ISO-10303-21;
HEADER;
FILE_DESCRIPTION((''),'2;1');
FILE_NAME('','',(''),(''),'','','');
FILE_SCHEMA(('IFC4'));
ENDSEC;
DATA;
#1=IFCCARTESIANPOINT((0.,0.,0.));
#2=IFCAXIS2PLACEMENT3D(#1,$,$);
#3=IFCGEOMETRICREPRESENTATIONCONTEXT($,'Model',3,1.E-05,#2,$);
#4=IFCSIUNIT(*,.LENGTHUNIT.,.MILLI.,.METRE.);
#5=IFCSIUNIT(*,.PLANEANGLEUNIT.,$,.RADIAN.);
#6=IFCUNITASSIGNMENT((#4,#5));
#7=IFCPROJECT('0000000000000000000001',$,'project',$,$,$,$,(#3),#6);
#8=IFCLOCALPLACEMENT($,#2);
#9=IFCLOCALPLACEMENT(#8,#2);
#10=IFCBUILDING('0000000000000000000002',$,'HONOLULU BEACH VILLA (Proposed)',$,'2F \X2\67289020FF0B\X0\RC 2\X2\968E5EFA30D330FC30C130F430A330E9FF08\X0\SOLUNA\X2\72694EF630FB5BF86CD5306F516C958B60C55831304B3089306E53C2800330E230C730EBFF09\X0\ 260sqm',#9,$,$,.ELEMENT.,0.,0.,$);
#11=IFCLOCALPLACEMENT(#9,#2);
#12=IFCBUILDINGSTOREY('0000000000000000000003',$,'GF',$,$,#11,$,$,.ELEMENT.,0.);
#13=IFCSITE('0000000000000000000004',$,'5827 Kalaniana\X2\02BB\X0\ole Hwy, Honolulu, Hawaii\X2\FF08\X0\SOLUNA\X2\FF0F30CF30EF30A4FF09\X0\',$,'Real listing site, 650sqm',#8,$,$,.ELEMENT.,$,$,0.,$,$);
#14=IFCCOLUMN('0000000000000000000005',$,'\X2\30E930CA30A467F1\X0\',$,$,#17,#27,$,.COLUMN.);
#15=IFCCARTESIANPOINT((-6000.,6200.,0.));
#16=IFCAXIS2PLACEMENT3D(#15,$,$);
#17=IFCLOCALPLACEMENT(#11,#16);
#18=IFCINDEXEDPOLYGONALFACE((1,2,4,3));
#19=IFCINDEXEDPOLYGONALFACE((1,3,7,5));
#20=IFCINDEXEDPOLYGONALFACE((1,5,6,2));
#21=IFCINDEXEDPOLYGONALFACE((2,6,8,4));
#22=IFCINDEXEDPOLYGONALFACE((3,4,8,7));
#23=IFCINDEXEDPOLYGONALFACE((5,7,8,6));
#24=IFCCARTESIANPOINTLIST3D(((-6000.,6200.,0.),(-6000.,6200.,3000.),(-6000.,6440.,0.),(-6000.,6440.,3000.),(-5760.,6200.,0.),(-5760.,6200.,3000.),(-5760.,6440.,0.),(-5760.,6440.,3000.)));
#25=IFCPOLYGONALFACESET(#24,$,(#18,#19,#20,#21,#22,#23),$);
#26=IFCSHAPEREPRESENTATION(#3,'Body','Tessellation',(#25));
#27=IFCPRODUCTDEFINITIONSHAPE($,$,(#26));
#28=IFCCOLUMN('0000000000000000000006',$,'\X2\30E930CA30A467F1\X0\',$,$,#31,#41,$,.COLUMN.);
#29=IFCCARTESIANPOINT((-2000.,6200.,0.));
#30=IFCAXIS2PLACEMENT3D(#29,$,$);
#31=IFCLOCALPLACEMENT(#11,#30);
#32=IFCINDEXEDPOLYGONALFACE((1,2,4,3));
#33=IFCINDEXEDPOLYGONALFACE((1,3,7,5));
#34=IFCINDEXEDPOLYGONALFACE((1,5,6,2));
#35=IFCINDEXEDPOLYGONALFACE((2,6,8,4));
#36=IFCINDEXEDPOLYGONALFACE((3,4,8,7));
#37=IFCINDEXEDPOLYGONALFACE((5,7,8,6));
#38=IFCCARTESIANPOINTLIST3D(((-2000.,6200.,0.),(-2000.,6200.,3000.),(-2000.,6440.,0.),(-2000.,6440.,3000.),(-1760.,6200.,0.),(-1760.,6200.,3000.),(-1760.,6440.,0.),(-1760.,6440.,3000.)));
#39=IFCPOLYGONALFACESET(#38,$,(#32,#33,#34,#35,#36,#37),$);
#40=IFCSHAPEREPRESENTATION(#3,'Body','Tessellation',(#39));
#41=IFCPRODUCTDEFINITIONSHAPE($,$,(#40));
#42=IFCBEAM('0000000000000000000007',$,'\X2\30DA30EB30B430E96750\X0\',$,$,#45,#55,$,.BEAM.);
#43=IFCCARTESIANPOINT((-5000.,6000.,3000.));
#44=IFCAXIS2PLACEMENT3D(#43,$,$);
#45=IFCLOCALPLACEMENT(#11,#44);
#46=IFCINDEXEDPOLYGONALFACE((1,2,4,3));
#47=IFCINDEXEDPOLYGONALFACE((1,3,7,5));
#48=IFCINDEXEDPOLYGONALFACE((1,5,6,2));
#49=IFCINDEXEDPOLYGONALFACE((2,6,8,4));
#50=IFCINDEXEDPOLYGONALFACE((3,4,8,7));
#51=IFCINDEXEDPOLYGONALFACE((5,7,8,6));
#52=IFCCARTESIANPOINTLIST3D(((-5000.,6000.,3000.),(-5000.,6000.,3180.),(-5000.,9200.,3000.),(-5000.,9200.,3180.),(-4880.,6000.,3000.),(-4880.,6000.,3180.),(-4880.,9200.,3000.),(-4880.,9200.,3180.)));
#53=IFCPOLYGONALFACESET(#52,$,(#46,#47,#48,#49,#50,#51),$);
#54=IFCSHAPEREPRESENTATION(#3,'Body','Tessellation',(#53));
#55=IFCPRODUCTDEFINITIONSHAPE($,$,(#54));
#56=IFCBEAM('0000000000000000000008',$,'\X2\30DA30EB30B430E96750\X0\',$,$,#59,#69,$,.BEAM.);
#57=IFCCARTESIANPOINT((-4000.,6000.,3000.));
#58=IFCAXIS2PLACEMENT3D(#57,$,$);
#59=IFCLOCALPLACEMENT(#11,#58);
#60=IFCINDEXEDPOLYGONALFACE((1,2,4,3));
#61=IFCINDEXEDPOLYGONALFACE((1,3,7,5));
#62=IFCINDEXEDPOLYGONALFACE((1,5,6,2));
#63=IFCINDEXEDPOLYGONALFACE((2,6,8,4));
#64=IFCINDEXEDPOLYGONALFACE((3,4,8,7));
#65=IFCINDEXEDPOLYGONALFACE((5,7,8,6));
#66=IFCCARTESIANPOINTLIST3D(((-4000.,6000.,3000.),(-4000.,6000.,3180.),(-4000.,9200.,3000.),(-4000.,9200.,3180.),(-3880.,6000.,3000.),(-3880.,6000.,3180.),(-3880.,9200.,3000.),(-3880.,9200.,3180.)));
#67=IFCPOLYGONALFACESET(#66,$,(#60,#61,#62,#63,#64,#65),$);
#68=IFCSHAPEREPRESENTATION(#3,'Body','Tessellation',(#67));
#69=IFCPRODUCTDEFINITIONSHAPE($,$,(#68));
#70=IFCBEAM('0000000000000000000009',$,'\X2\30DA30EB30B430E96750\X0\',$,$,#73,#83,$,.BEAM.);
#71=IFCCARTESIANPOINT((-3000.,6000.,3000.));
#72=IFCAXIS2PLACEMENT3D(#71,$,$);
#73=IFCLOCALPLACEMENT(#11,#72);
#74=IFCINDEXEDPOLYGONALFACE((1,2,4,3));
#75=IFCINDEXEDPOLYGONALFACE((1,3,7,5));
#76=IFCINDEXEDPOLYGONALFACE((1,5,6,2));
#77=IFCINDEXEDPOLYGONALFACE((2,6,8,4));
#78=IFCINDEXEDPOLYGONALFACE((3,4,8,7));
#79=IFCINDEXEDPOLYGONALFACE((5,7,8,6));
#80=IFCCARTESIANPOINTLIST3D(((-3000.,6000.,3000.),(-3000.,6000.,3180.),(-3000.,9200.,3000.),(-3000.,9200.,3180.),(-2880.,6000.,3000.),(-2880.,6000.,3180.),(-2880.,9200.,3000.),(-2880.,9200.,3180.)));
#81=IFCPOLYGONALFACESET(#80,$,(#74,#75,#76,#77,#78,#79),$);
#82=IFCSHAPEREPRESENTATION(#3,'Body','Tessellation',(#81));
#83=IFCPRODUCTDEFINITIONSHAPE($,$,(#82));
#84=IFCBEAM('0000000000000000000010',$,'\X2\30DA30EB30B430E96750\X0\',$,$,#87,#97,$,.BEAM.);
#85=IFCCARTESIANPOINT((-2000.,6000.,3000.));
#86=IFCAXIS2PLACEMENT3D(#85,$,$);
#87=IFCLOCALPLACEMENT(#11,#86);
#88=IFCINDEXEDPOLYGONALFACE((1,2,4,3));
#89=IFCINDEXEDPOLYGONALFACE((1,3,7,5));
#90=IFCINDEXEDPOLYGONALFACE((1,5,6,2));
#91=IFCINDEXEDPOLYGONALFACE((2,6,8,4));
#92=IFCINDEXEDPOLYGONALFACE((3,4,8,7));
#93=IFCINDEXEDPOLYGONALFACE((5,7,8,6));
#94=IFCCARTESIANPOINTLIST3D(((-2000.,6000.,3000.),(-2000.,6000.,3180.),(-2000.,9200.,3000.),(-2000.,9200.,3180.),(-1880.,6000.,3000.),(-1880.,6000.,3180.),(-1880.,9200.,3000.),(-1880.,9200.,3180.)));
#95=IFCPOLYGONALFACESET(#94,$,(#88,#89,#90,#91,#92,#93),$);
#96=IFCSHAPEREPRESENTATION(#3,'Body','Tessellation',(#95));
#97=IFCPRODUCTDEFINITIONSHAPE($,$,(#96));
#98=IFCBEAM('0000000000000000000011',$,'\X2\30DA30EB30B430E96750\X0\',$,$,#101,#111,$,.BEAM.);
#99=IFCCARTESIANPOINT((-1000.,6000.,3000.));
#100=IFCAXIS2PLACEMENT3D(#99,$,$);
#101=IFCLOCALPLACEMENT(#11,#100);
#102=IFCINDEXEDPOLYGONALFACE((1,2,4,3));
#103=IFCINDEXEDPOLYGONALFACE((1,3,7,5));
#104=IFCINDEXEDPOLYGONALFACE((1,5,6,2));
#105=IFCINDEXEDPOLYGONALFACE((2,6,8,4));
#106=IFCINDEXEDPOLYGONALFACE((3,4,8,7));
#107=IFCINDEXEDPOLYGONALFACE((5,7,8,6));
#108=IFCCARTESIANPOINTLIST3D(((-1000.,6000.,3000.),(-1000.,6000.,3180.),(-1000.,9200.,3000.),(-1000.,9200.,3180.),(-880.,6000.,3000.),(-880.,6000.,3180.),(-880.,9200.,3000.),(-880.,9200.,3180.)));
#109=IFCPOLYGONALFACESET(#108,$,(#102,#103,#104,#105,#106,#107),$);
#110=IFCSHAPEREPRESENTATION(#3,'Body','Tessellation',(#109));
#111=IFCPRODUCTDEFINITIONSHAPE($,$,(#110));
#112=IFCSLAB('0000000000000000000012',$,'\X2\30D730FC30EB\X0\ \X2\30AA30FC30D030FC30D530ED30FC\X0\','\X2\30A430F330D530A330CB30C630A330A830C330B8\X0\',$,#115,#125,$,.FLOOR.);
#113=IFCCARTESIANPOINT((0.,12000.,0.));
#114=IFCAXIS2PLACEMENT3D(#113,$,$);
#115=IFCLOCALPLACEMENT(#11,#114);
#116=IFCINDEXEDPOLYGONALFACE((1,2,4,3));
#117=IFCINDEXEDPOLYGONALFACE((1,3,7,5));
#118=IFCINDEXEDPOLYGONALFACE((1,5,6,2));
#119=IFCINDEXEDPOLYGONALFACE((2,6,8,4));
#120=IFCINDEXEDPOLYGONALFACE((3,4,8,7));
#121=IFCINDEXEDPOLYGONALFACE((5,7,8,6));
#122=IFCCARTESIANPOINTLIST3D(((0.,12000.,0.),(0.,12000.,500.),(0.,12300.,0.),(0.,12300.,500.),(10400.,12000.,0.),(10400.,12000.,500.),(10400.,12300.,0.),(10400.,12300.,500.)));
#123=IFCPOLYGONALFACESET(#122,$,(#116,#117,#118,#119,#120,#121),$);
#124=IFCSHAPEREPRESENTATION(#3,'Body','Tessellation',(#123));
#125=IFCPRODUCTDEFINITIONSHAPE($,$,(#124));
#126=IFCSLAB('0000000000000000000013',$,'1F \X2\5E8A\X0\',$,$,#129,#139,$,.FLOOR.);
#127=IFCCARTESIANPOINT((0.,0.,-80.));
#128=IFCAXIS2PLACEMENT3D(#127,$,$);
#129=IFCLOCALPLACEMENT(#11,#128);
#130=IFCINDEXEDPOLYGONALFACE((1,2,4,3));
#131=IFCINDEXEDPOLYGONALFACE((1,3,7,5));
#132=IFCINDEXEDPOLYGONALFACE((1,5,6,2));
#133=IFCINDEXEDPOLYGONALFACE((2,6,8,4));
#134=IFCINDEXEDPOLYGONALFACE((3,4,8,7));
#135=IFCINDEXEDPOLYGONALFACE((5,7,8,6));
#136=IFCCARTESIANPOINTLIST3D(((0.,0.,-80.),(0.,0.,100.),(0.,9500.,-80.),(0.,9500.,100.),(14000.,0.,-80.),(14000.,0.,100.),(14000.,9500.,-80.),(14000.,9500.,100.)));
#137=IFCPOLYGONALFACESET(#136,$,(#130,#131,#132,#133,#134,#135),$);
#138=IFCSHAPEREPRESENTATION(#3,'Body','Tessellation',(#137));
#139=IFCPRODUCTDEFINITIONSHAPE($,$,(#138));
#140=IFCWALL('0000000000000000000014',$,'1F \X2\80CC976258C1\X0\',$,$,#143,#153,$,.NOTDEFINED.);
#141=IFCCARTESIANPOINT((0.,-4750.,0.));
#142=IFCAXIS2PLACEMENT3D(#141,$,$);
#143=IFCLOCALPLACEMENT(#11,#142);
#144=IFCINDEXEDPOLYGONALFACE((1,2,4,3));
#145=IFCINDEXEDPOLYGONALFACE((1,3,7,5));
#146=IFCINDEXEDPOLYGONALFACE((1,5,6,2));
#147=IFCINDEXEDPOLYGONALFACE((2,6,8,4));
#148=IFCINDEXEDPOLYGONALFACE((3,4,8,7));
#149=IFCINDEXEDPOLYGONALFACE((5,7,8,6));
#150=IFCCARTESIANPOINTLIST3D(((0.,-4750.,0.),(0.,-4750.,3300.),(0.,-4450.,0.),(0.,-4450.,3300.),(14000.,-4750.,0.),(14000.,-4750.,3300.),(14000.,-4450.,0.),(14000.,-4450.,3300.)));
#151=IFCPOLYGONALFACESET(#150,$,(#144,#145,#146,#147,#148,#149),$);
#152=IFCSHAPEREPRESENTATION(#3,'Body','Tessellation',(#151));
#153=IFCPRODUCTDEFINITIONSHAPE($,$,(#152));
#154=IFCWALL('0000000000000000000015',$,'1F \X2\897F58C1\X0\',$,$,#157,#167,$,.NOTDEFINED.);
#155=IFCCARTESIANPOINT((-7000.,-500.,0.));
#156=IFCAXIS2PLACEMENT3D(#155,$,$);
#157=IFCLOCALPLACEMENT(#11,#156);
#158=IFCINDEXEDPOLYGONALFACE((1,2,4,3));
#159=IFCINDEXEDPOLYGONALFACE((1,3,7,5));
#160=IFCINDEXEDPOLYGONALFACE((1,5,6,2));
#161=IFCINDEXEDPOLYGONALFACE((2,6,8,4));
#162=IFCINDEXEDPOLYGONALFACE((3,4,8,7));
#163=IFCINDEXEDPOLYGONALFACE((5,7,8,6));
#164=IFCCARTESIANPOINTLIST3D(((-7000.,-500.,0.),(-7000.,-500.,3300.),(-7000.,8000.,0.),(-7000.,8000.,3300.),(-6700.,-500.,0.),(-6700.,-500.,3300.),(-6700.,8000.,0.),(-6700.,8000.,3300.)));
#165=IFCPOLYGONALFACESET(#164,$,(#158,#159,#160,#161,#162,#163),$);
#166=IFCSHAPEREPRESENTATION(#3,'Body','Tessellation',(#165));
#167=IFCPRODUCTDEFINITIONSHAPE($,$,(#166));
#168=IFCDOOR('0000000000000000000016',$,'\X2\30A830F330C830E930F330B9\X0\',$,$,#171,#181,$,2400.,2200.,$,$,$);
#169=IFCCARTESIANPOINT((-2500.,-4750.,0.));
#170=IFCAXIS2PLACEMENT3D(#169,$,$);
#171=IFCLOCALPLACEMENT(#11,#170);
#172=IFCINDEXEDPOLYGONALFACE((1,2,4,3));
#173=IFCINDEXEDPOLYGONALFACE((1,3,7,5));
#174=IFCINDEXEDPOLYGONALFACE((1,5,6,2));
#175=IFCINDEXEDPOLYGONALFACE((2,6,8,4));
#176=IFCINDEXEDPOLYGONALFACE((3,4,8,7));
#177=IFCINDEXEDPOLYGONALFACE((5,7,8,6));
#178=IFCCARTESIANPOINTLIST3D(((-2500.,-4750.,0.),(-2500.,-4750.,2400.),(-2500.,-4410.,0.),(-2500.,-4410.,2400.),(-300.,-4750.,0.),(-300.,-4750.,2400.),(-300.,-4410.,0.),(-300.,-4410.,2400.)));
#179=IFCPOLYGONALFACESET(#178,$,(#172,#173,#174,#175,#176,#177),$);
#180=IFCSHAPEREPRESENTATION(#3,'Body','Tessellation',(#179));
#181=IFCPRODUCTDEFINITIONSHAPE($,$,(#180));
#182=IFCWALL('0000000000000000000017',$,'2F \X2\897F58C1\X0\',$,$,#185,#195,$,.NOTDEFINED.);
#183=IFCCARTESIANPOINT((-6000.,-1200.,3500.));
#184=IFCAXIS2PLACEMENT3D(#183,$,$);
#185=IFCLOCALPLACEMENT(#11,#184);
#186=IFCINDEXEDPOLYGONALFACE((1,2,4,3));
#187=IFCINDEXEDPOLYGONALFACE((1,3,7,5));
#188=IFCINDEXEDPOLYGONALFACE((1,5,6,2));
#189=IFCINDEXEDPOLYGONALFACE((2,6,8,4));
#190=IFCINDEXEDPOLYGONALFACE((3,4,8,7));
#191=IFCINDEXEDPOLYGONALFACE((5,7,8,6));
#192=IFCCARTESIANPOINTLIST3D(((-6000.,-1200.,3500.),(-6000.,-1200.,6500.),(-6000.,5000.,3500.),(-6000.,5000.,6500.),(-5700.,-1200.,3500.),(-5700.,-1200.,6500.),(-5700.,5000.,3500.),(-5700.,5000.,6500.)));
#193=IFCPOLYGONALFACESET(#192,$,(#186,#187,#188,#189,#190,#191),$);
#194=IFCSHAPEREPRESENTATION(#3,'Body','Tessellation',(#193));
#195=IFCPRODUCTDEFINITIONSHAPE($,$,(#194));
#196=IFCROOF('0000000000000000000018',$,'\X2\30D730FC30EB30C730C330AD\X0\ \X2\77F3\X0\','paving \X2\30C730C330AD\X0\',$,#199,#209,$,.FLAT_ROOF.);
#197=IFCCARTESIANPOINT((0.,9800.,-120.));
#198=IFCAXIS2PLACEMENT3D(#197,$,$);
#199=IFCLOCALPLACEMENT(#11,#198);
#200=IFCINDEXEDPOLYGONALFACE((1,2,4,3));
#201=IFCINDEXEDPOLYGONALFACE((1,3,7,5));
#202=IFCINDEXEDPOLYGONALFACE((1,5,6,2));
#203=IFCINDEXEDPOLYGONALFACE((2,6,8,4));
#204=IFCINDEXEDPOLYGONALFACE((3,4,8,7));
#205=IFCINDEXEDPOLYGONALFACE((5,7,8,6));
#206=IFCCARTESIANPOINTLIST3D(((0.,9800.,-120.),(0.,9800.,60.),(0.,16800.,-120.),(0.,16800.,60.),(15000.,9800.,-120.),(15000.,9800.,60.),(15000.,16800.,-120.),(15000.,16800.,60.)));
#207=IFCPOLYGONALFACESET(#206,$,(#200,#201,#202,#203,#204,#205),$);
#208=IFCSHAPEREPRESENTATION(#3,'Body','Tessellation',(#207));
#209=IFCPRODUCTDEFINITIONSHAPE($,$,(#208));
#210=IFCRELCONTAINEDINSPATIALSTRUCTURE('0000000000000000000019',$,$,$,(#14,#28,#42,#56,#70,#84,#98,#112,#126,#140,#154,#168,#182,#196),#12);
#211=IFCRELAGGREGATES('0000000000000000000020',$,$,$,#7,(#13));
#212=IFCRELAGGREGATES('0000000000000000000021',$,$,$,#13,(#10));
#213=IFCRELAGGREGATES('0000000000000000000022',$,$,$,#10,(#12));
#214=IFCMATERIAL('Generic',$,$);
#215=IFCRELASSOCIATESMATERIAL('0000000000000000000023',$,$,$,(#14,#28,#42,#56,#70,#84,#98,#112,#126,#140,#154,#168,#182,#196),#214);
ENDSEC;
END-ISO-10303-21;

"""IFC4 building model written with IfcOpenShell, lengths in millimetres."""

from ifc_helpers import new_model, si_unit, frame, frame_2d, origin, place, context, project, spatial, rectangle, extrude, material, element, save


model = new_model("IFC4")

# Units and contexts
model_context = context("Model", 3, precision=1e-05, world=origin())
ifc_project = project(units=[si_unit("LENGTHUNIT", "METRE", prefix="MILLI"), si_unit("PLANEANGLEUNIT", "RADIAN")], contexts=[model_context])

# Site, building, storey
site_placement = place(None, origin())
site = spatial("IfcSite", under=ifc_project, at=site_placement, Name="5827 Kalanianaʻole Hwy, Honolulu, Hawaii（SOLUNA／ハワイ）", ObjectType="Real listing site, 650sqm", CompositionType="ELEMENT", RefElevation=0.0)
building_placement = place(site_placement, origin())
building = spatial("IfcBuilding", under=site, at=building_placement, Name="HONOLULU BEACH VILLA (Proposed)", ObjectType="2F 木造＋RC 2階建ビーチヴィラ（SOLUNA物件・寸法は公開情報からの参考モデル） 260sqm", CompositionType="ELEMENT", ElevationOfRefHeight=0.0, ElevationOfTerrain=0.0)
storey_placement = place(building_placement, origin())
storey = spatial("IfcBuildingStorey", under=building, at=storey_placement, Name="GF", CompositionType="ELEMENT", Elevation=0.0)

# Columns
ifc_material_1 = material(Name="Generic")
column_1_placement = place(storey_placement, frame((-6000.0, 6200.0, 0.0)))
element("IfcColumn", 1, at=column_1_placement, inside=storey, material=ifc_material_1, Name="ラナイ柱", PredefinedType="COLUMN", context=model_context, shape_type="SweptSolid", body=[
    extrude(rectangle(XDim=240.0, YDim=240.0, at=frame_2d((120.0, 120.0))), frame((-6000.0, 6200.0, 0.0)), (0.0, 0.0, 1.0), 3000.0),
])
column_2_placement = place(storey_placement, frame((-2000.0, 6200.0, 0.0)))
element("IfcColumn", 2, at=column_2_placement, inside=storey, material=ifc_material_1, Name="ラナイ柱", PredefinedType="COLUMN", context=model_context, shape_type="SweptSolid", body=[
    extrude(rectangle(XDim=240.0, YDim=240.0, at=frame_2d((120.0, 120.0))), frame((-2000.0, 6200.0, 0.0)), (0.0, 0.0, 1.0), 3000.0),
])

# Beams
beam_1_placement = place(storey_placement, frame((-5000.0, 6000.0, 3000.0)))
element("IfcBeam", 3, at=beam_1_placement, inside=storey, material=ifc_material_1, Name="ペルゴラ材", PredefinedType="BEAM", context=model_context, shape_type="SweptSolid", body=[
    extrude(rectangle(XDim=120.0, YDim=3200.0, at=frame_2d((60.0, 1600.0))), frame((-5000.0, 6000.0, 3000.0)), (0.0, 0.0, 1.0), 180.0),
])
beam_2_placement = place(storey_placement, frame((-4000.0, 6000.0, 3000.0)))
element("IfcBeam", 4, at=beam_2_placement, inside=storey, material=ifc_material_1, Name="ペルゴラ材", PredefinedType="BEAM", context=model_context, shape_type="SweptSolid", body=[
    extrude(rectangle(XDim=120.0, YDim=3200.0, at=frame_2d((60.0, 1600.0))), frame((-4000.0, 6000.0, 3000.0)), (0.0, 0.0, 1.0), 180.0),
])
beam_3_placement = place(storey_placement, frame((-3000.0, 6000.0, 3000.0)))
element("IfcBeam", 5, at=beam_3_placement, inside=storey, material=ifc_material_1, Name="ペルゴラ材", PredefinedType="BEAM", context=model_context, shape_type="SweptSolid", body=[
    extrude(rectangle(XDim=120.0, YDim=3200.0, at=frame_2d((60.0, 1600.0))), frame((-3000.0, 6000.0, 3000.0)), (0.0, 0.0, 1.0), 180.0),
])
beam_4_placement = place(storey_placement, frame((-2000.0, 6000.0, 3000.0)))
element("IfcBeam", 6, at=beam_4_placement, inside=storey, material=ifc_material_1, Name="ペルゴラ材", PredefinedType="BEAM", context=model_context, shape_type="SweptSolid", body=[
    extrude(rectangle(XDim=120.0, YDim=3200.0, at=frame_2d((60.0, 1600.0))), frame((-2000.0, 6000.0, 3000.0)), (0.0, 0.0, 1.0), 180.0),
])
beam_5_placement = place(storey_placement, frame((-1000.0, 6000.0, 3000.0)))
element("IfcBeam", 7, at=beam_5_placement, inside=storey, material=ifc_material_1, Name="ペルゴラ材", PredefinedType="BEAM", context=model_context, shape_type="SweptSolid", body=[
    extrude(rectangle(XDim=120.0, YDim=3200.0, at=frame_2d((60.0, 1600.0))), frame((-1000.0, 6000.0, 3000.0)), (0.0, 0.0, 1.0), 180.0),
])

# Slabs
slab_1_placement = place(storey_placement, frame((0.0, 12000.0, 0.0)))
element("IfcSlab", 8, at=slab_1_placement, inside=storey, material=ifc_material_1, Name="プール オーバーフロー", Description="インフィニティエッジ", PredefinedType="FLOOR", context=model_context, shape_type="SweptSolid", body=[
    extrude(rectangle(XDim=10400.0, YDim=300.0, at=frame_2d((5200.0, 150.0))), frame((0.0, 12000.0, 0.0)), (0.0, 0.0, 1.0), 500.0),
])
slab_2_placement = place(storey_placement, frame((0.0, 0.0, -80.0)))
element("IfcSlab", 9, at=slab_2_placement, inside=storey, material=ifc_material_1, Name="1F 床", PredefinedType="FLOOR", context=model_context, shape_type="SweptSolid", body=[
    extrude(rectangle(XDim=14000.0, YDim=9500.0, at=frame_2d((7000.0, 4750.0))), frame((0.0, 0.0, -80.0)), (0.0, 0.0, 1.0), 180.0),
])

# Walls
wall_1_placement = place(storey_placement, frame((0.0, -4750.0, 0.0)))
element("IfcWall", 10, at=wall_1_placement, inside=storey, material=ifc_material_1, Name="1F 背面壁", PredefinedType="NOTDEFINED", context=model_context, shape_type="SweptSolid", body=[
    extrude(rectangle(XDim=14000.0, YDim=300.0, at=frame_2d((7000.0, 150.0))), frame((0.0, -4750.0, 0.0)), (0.0, 0.0, 1.0), 3300.0),
])
wall_2_placement = place(storey_placement, frame((-7000.0, -500.0, 0.0)))
element("IfcWall", 11, at=wall_2_placement, inside=storey, material=ifc_material_1, Name="1F 西壁", PredefinedType="NOTDEFINED", context=model_context, shape_type="SweptSolid", body=[
    extrude(rectangle(XDim=300.0, YDim=8500.0, at=frame_2d((150.0, 4250.0))), frame((-7000.0, -500.0, 0.0)), (0.0, 0.0, 1.0), 3300.0),
])

# Door
door_placement = place(storey_placement, frame((-2500.0, -4750.0, 0.0)))
element("IfcDoor", 12, at=door_placement, inside=storey, material=ifc_material_1, Name="エントランス", OverallHeight=2400.0, OverallWidth=2200.0, context=model_context, shape_type="SweptSolid", body=[
    extrude(rectangle(XDim=2200.0, YDim=340.0, at=frame_2d((1100.0, 170.0))), frame((-2500.0, -4750.0, 0.0)), (0.0, 0.0, 1.0), 2400.0),
])

# Wall
wall_3_placement = place(storey_placement, frame((-6000.0, -1200.0, 3500.0)))
element("IfcWall", 13, at=wall_3_placement, inside=storey, material=ifc_material_1, Name="2F 西壁", PredefinedType="NOTDEFINED", context=model_context, shape_type="SweptSolid", body=[
    extrude(rectangle(XDim=300.0, YDim=6200.0, at=frame_2d((150.0, 3100.0))), frame((-6000.0, -1200.0, 3500.0)), (0.0, 0.0, 1.0), 3000.0),
])

# Roof
roof_1_placement = place(storey_placement, frame((0.0, 9800.0, -120.0)))
element("IfcRoof", 14, at=roof_1_placement, inside=storey, material=ifc_material_1, Name="プールデッキ 石", Description="paving デッキ", PredefinedType="FLAT_ROOF", context=model_context, shape_type="SweptSolid", body=[
    extrude(rectangle(XDim=15000.0, YDim=7000.0, at=frame_2d((7500.0, 3500.0))), frame((0.0, 9800.0, -120.0)), (0.0, 0.0, 1.0), 180.0),
])

save(model, "model.ifc")
